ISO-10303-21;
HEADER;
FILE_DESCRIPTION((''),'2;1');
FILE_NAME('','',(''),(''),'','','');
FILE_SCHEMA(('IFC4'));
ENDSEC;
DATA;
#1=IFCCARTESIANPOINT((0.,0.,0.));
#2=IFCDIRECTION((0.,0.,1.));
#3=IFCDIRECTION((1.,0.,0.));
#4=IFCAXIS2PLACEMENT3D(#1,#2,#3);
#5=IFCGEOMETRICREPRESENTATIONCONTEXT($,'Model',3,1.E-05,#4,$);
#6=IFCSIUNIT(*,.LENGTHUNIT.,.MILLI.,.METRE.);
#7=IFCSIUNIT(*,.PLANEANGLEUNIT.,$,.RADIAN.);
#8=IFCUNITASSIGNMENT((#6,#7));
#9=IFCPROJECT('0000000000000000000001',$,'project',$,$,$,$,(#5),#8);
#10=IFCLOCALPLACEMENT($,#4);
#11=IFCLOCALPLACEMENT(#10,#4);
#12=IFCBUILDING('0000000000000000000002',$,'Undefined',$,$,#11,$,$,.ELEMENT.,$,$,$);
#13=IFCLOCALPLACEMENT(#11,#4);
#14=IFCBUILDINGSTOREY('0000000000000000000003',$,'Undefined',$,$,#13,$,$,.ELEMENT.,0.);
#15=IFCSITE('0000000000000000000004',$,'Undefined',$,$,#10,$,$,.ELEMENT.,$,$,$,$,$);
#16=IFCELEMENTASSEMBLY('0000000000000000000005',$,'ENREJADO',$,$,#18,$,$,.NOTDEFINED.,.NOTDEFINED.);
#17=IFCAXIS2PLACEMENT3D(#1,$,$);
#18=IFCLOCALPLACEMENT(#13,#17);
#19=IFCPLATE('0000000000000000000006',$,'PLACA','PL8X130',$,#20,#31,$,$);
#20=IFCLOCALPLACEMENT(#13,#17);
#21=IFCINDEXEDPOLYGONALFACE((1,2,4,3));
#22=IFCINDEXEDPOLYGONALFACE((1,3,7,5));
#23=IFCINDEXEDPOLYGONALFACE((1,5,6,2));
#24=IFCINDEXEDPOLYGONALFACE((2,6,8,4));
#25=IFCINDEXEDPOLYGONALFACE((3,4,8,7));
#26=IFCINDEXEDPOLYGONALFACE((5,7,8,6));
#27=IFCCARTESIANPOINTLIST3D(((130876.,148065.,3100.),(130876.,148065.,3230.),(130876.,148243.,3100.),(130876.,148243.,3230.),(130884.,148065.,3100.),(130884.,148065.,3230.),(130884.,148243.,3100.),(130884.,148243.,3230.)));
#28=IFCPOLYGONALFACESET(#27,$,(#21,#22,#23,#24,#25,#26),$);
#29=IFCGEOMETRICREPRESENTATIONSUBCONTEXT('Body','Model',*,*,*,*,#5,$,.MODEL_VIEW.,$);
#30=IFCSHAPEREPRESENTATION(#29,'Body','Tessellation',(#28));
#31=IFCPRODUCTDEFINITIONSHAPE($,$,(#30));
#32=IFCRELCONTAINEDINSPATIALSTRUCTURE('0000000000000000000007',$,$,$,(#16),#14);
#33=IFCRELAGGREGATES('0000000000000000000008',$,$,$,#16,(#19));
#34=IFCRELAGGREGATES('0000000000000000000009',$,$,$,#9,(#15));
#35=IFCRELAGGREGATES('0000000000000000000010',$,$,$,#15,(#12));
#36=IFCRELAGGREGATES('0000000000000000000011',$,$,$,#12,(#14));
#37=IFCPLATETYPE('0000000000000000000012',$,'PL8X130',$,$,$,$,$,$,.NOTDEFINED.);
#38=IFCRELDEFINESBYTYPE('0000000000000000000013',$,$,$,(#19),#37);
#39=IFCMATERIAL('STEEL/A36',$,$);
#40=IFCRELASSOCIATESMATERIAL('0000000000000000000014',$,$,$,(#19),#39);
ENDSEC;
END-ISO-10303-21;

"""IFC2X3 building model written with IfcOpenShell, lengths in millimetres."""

from ifc_helpers import new_model, si_unit, frame, origin_with_axes, place, context, subcontext, project, spatial, polyline, outline, extrude, material, type_object, element, aggregate, save


model = new_model("IFC2X3")

# Units and contexts
model_context = context("Model", 3, precision=1e-05, world=origin_with_axes())
body_context = subcontext(model_context, "Body", "Model", "MODEL_VIEW")
ifc_project = project(units=[si_unit("LENGTHUNIT", "METRE", prefix="MILLI"), si_unit("PLANEANGLEUNIT", "RADIAN")], contexts=[model_context])

# Site, building, storey
site_placement = place(None, origin_with_axes())
site = spatial("IfcSite", under=ifc_project, at=site_placement, Name="Undefined", CompositionType="ELEMENT")
building_placement = place(site_placement, origin_with_axes())
building = spatial("IfcBuilding", under=site, at=building_placement, Name="Undefined", CompositionType="ELEMENT")
storey_placement = place(building_placement, origin_with_axes())
storey = spatial("IfcBuildingStorey", under=building, at=storey_placement, Name="Undefined", CompositionType="ELEMENT", Elevation=0.0)

# Shared definitions
ifc_material_1 = material(Name="STEEL/A36")

# Element assembly
assembly_1_placement = place(storey_placement, origin_with_axes())
assembly_1 = element("IfcElementAssembly", 1, at=assembly_1_placement, inside=storey, Name="ENREJADO", AssemblyPlace="NOTDEFINED", PredefinedType="NOTDEFINED")

# Plate
plate_type_1 = type_object("IfcPlateType", Name="PL8X130", PredefinedType="NOTDEFINED")
plate_1_placement = place(assembly_1_placement, frame((130880.0, 148065.0, 3165.0), z_axis=(-1.0, 0.000001, 0.0), x_axis=(0.000001, 1.0, 0.0)))
plate_1 = element("IfcPlate", 2, at=plate_1_placement, type_object=plate_type_1, material=ifc_material_1, Name="PLACA", Description="PL8X130", context=body_context, shape_type="SweptSolid", body=[
    extrude(outline(polyline([(0.0, -65.0), (0.0, 65.0), (178.0, 65.0), (178.0, -65.0), (0.0, -65.0)])), frame((0.0, 0.0, -4.0), z_axis=(0.0, 0.0, 1.0), x_axis=(1.0, 0.0, 0.0)), (0.0, 0.0, 1.0), 8.0),
])
aggregate(assembly_1, [plate_1])

save(model, "model.ifc")
